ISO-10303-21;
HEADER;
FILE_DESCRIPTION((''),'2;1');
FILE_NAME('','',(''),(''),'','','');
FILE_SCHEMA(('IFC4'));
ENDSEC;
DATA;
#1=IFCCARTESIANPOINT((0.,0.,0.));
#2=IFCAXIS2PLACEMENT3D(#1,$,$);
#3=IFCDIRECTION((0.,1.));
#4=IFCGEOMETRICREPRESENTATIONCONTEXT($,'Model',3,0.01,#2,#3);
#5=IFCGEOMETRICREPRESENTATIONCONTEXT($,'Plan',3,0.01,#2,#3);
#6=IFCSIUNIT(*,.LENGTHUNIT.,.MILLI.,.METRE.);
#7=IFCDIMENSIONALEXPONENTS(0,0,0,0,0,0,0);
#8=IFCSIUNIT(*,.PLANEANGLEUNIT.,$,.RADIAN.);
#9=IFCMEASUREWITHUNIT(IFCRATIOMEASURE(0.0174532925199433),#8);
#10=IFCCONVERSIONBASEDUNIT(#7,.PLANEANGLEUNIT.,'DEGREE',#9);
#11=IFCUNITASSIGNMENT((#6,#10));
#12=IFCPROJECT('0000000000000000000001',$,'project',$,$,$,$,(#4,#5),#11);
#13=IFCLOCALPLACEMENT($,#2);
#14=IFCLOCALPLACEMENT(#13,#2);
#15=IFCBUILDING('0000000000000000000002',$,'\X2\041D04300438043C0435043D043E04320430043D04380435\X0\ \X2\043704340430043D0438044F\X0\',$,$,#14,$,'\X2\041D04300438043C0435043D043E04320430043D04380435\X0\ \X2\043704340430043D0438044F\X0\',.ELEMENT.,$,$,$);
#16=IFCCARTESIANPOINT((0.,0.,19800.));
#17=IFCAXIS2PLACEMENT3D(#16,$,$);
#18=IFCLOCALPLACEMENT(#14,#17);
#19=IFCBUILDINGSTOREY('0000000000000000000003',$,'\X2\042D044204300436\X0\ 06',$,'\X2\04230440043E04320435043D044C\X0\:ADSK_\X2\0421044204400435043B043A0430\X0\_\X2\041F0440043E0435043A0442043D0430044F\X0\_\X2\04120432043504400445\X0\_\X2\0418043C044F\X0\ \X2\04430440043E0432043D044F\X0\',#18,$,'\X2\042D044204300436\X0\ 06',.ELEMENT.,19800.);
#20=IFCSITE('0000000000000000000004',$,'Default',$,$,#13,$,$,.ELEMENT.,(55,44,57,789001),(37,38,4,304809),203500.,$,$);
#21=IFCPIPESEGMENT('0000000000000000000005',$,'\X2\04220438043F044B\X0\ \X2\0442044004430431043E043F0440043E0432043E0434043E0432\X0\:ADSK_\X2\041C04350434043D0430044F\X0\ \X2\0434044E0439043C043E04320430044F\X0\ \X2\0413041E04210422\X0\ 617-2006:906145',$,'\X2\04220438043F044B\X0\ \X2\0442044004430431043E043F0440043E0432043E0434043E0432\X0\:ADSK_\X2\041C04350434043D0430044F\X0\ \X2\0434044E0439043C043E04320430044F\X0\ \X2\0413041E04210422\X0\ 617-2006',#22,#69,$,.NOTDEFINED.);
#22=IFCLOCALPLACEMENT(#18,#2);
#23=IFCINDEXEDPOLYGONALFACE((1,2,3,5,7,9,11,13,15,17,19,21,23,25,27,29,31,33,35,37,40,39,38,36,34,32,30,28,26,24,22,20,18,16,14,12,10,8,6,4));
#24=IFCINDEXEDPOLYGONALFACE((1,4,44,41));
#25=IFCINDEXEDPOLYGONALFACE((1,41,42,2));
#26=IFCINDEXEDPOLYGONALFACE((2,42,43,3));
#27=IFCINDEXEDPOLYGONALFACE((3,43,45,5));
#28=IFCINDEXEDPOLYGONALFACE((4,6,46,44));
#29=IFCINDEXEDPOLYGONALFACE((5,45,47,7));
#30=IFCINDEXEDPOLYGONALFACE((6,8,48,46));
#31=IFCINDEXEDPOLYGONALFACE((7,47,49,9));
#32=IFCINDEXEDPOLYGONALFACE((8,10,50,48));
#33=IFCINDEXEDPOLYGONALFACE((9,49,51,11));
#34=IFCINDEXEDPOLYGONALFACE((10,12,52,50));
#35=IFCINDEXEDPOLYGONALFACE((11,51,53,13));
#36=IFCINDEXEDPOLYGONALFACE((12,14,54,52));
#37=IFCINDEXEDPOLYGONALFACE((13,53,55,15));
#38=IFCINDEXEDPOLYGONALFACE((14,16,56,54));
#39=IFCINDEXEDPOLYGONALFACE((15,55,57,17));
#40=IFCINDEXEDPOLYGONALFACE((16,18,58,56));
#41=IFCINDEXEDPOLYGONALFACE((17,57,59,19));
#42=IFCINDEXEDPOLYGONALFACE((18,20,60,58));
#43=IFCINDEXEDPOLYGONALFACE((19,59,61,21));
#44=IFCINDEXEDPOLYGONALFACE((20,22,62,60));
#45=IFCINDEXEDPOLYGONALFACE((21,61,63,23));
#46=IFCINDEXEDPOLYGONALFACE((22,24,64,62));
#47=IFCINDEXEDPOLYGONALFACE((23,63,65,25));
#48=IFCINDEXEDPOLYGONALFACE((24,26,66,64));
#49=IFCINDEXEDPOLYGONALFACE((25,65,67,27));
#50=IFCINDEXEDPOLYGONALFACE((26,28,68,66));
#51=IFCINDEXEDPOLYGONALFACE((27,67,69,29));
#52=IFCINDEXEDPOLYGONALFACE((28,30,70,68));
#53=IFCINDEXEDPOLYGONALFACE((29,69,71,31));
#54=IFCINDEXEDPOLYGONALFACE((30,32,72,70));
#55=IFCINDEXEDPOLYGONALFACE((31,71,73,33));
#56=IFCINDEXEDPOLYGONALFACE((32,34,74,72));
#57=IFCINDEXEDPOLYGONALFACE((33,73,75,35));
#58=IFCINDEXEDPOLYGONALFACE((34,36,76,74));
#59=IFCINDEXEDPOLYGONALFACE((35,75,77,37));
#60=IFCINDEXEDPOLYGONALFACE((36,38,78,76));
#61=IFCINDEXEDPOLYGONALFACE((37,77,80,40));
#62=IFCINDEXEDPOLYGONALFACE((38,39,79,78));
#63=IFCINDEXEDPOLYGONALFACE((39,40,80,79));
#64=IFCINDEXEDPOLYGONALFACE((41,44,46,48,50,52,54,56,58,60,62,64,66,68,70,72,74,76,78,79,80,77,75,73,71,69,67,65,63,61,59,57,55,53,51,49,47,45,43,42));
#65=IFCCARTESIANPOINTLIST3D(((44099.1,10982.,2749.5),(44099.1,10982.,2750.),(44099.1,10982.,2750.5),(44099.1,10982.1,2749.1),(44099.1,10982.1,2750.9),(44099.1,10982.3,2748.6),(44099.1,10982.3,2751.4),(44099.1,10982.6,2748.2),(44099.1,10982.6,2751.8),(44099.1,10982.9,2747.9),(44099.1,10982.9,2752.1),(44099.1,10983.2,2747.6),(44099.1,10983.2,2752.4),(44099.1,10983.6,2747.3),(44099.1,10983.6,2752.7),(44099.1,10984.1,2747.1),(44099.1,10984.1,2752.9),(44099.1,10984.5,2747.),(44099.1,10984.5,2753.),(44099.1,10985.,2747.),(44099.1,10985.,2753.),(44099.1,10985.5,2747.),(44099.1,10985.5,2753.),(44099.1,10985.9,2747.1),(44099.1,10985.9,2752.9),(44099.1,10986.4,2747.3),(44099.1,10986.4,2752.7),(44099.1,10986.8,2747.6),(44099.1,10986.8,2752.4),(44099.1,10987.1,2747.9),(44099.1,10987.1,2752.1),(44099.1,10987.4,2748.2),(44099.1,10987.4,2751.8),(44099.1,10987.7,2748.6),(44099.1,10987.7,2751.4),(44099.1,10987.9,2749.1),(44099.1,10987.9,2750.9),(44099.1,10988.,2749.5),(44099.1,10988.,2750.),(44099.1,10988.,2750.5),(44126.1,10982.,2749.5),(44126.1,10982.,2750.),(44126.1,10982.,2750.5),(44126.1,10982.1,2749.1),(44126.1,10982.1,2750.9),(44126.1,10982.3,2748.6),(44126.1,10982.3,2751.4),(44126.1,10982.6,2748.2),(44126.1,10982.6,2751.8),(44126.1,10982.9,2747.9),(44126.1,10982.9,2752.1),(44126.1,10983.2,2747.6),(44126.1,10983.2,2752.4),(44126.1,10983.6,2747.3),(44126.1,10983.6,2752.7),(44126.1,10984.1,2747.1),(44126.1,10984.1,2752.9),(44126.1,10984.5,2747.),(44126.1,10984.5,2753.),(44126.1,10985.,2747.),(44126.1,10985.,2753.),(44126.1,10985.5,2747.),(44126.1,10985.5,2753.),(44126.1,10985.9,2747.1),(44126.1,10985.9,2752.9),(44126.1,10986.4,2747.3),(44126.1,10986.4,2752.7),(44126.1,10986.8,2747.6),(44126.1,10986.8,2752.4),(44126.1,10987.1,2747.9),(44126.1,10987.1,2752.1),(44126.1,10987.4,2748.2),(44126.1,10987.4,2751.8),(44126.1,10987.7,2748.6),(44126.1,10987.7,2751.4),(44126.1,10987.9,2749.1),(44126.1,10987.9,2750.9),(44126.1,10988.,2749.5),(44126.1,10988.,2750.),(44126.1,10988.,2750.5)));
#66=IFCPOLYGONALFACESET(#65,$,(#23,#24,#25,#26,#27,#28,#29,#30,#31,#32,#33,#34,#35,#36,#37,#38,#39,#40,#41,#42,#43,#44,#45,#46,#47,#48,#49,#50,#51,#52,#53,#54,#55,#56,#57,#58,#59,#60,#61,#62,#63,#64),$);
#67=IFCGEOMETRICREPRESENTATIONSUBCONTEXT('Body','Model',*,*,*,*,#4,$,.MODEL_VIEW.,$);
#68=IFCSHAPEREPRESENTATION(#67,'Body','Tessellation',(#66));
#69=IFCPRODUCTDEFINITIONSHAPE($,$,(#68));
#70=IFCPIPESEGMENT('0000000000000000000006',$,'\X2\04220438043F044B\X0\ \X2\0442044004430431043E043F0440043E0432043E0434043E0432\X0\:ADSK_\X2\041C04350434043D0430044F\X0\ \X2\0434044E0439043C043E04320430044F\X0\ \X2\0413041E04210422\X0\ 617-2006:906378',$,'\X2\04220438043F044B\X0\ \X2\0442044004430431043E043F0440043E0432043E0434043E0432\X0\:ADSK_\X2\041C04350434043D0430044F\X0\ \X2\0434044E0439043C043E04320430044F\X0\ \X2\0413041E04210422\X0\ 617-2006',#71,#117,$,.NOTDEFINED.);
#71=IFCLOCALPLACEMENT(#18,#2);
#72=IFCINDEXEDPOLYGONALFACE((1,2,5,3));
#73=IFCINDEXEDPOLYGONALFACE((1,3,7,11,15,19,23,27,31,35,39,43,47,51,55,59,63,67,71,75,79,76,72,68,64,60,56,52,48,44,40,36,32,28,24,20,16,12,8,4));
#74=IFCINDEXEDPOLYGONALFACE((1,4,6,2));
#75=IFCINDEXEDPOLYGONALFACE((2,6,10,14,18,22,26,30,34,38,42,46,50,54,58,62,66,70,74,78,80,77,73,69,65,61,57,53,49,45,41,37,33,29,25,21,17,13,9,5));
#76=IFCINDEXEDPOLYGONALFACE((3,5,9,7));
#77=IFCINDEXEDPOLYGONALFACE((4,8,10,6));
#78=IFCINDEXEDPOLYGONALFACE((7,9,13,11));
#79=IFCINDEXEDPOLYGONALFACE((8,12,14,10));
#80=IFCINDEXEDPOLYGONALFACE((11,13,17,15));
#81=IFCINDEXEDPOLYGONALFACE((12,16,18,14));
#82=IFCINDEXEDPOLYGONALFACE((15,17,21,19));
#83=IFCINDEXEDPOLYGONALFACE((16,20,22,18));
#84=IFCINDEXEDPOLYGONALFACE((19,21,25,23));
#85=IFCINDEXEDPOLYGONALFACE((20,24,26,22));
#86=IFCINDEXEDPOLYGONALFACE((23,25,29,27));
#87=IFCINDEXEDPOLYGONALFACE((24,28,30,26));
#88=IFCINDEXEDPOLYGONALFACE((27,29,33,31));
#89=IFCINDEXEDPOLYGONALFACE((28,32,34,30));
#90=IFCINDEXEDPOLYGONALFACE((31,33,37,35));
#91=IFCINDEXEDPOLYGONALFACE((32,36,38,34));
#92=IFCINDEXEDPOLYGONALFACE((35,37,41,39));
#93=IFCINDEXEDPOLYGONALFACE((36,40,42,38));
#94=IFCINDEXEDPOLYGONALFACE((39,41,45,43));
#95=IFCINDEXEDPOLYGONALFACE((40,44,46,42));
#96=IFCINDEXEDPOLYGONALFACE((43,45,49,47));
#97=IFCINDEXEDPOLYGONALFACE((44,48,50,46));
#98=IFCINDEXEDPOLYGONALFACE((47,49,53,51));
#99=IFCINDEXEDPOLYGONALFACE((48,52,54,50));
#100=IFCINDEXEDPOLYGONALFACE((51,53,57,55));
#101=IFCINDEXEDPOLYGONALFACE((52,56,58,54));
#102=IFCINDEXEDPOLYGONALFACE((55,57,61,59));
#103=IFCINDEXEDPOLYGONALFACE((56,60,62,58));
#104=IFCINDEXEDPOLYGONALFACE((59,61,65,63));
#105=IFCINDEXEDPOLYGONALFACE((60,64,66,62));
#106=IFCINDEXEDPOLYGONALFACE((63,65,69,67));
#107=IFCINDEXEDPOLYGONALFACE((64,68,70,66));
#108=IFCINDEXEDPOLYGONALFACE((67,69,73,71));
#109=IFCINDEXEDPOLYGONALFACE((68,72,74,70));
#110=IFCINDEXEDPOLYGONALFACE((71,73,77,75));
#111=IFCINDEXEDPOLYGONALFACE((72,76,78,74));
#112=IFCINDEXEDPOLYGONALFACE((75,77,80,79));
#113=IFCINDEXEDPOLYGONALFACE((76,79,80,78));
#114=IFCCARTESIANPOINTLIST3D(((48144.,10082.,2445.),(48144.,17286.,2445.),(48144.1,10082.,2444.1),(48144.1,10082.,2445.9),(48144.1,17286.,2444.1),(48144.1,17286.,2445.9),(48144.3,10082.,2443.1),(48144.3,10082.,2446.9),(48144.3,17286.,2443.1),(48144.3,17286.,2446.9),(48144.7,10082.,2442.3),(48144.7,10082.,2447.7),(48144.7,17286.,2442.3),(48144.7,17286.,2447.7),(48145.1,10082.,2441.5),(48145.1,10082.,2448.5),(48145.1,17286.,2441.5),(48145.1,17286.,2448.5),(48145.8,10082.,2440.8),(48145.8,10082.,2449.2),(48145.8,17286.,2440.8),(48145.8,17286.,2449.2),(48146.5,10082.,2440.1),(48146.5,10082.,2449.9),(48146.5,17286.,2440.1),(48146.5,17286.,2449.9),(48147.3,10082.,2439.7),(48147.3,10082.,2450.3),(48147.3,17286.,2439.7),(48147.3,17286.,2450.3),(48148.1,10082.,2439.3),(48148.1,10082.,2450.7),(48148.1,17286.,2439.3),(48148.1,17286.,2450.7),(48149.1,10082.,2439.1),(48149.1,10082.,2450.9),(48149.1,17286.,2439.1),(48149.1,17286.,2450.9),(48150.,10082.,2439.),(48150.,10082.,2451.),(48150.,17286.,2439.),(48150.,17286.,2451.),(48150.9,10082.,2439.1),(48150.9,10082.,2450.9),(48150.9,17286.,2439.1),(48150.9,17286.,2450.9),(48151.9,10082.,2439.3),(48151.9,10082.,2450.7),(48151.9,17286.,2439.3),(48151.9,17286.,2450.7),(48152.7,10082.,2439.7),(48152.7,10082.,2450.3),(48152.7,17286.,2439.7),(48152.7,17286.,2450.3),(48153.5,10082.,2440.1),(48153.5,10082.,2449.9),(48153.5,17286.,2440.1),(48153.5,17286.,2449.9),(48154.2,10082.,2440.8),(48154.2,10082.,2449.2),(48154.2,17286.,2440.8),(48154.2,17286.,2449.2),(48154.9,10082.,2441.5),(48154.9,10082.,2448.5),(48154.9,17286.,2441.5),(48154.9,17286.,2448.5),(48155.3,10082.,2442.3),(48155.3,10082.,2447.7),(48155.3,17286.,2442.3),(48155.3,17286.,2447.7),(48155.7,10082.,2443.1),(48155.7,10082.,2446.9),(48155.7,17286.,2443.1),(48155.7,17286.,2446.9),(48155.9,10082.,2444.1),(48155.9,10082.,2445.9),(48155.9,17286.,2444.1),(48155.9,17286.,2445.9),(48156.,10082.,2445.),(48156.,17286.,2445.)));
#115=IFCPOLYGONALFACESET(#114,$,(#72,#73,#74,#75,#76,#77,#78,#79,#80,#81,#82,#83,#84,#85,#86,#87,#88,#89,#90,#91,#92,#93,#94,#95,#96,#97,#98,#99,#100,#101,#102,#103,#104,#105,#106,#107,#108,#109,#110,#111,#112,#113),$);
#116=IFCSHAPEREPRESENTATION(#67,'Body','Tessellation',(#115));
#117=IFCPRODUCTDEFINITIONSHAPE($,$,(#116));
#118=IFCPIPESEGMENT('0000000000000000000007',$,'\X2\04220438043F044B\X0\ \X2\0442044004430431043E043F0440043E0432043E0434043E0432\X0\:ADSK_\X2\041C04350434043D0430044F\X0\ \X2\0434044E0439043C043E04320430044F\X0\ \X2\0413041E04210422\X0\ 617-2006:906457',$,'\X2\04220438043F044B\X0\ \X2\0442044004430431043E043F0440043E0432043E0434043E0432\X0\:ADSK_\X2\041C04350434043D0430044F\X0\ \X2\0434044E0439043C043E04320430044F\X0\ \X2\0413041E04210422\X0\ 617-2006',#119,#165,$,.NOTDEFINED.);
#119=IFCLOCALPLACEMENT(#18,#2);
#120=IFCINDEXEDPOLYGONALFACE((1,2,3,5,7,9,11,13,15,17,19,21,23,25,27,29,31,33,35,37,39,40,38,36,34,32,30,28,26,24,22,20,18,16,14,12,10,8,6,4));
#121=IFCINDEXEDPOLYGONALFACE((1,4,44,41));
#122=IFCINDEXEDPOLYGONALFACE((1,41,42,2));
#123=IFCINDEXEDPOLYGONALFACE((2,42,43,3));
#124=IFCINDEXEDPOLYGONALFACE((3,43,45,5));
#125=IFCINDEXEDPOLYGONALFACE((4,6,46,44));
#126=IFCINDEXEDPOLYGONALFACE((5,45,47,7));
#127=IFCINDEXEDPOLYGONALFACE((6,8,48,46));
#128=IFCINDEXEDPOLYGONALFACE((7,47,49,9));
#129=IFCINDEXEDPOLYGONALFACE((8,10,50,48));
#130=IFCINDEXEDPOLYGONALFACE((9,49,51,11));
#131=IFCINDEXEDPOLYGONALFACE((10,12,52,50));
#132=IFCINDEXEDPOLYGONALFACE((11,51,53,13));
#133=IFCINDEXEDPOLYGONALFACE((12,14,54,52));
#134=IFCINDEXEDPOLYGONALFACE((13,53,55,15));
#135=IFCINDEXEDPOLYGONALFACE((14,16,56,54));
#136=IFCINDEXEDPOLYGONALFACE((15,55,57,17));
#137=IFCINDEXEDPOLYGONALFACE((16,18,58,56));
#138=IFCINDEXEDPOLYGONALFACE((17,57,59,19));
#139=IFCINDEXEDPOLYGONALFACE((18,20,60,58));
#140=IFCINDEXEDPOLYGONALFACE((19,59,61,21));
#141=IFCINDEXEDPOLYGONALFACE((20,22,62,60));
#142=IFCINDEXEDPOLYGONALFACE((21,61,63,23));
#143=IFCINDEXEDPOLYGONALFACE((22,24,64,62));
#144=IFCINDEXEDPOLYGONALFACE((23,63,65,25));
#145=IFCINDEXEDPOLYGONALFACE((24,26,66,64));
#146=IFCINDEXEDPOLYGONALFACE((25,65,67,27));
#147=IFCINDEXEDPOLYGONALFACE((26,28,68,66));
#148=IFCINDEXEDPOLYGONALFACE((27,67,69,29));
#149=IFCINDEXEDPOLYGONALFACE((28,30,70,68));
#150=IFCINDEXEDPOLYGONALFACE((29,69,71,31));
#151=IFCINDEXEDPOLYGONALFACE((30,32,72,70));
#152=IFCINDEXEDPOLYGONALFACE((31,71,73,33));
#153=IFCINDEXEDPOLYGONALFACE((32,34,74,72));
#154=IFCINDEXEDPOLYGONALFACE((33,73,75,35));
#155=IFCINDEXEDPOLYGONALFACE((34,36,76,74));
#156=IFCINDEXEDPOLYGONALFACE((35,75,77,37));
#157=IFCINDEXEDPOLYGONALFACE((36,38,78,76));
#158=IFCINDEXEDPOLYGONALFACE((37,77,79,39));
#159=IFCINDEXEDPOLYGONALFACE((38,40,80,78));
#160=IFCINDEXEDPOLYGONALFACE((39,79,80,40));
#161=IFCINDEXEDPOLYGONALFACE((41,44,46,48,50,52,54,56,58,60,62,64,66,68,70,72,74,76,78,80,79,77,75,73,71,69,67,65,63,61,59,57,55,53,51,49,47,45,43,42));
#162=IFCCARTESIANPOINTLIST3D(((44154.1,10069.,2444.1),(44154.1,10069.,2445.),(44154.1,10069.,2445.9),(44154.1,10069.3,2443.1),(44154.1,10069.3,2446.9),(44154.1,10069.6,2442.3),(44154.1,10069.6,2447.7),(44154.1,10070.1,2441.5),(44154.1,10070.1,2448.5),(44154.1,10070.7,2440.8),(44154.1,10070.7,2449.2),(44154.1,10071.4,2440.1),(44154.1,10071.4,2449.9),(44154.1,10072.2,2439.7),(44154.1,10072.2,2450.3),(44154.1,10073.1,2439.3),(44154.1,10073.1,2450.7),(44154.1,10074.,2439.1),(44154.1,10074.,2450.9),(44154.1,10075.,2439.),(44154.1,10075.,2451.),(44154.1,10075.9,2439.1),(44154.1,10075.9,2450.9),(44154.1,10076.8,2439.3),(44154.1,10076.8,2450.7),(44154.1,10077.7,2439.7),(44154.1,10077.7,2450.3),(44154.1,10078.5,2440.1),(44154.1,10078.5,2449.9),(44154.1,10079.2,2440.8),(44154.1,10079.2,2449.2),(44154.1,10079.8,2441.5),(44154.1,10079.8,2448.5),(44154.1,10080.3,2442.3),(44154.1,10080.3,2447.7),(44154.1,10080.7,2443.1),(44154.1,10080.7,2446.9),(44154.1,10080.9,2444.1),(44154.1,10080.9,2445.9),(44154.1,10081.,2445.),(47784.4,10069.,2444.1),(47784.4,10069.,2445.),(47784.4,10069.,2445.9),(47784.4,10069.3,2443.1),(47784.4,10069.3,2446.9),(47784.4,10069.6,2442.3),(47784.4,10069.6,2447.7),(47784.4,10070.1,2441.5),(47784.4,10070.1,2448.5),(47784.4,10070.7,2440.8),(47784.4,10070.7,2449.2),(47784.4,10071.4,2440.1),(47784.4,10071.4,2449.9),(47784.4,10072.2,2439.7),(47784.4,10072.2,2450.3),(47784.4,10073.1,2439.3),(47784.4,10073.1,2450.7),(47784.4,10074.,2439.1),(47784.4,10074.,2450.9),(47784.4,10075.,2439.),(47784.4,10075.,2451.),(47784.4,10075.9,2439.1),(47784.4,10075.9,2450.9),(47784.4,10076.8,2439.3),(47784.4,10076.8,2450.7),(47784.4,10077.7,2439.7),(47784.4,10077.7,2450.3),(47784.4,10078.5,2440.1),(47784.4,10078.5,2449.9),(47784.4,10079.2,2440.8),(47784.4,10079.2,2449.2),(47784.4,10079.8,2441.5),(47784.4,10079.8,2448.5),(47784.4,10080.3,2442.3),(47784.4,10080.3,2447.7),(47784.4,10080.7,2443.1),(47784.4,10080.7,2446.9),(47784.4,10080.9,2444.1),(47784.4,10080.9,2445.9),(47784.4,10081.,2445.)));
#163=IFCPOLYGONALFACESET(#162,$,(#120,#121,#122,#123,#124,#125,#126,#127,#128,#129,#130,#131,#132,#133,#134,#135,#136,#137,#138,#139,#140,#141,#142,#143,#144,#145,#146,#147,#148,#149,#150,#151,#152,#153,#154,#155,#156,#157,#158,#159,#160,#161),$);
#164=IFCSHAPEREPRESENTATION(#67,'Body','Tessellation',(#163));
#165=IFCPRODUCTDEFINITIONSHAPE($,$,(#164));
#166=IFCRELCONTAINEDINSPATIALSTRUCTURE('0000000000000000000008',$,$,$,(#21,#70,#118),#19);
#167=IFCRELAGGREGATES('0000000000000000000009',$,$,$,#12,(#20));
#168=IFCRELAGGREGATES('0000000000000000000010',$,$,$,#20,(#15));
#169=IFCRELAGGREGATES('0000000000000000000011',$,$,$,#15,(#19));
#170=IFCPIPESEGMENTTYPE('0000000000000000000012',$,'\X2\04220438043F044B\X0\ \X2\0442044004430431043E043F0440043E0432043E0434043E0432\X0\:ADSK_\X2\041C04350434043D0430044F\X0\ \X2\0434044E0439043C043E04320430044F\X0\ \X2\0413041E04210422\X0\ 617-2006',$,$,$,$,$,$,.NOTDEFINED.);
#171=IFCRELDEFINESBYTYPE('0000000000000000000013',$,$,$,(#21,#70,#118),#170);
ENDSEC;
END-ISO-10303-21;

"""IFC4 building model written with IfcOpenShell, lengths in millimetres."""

from ifc_helpers import new_model, entity, si_unit, converted_unit, direction, frame, origin, place, context, subcontext, project, spatial, indexed_curve, outline, extrude, type_object, element, save


model = new_model("IFC4")

# Units and contexts
model_context = context("Model", 3, precision=0.01, world=origin(), true_north=direction((0.0, 1.0)))
plan_context = context("Plan", 3, precision=0.01, world=origin(), true_north=direction((0.0, 1.0)))
body_context = subcontext(model_context, "Body", "Model", "MODEL_VIEW")
ifc_project = project(units=[si_unit("LENGTHUNIT", "METRE", prefix="MILLI"), converted_unit("PLANEANGLEUNIT", "DEGREE", entity("IfcRatioMeasure", 0.0174532925199433), si_unit("PLANEANGLEUNIT", "RADIAN"), dimensions=[0, 0, 0, 0, 0, 0, 0])], contexts=[model_context, plan_context])

# Site, building, storey
site_placement = place(None, origin())
site = spatial("IfcSite", under=ifc_project, at=site_placement, Name="Default", CompositionType="ELEMENT", RefLatitude=(55, 44, 57, 789001), RefLongitude=(37, 38, 4, 304809), RefElevation=203500.0)
building_placement = place(site_placement, origin())
building = spatial("IfcBuilding", under=site, at=building_placement, Name="Наименование здания", LongName="Наименование здания", CompositionType="ELEMENT")
storey_placement = place(building_placement, frame((0.0, 0.0, 19800.0)))
storey = spatial("IfcBuildingStorey", under=building, at=storey_placement, Name="Этаж 06", ObjectType="Уровень:ADSK_Стрелка_Проектная_Вверх_Имя уровня", LongName="Этаж 06", CompositionType="ELEMENT", Elevation=19800.0)

# Pipe segments
pipe_segment_type = type_object("IfcPipeSegmentType", Name="Типы трубопроводов:ADSK_Медная дюймовая ГОСТ 617-2006", PredefinedType="NOTDEFINED")
placement = place(storey_placement, origin())
element("IfcPipeSegment", 1, at=placement, inside=storey, type_object=pipe_segment_type, Name="Типы трубопроводов:ADSK_Медная дюймовая ГОСТ 617-2006:906145", ObjectType="Типы трубопроводов:ADSK_Медная дюймовая ГОСТ 617-2006", PredefinedType="NOTDEFINED", context=body_context, shape_type="SweptSolid", body=[
    extrude(outline(indexed_curve([(3.0, 0.0), (3.0, 0.5), (2.9, 0.9), (2.7, 1.4), (2.4, 1.8), (2.1, 2.1), (1.8, 2.4), (1.4, 2.7), (0.9, 2.9), (0.5, 3.0), (0.0, 3.0), (-0.5, 3.0), (-0.9, 2.9), (-1.4, 2.7), (-1.8, 2.4), (-2.1, 2.1), (-2.4, 1.8), (-2.7, 1.4), (-2.9, 0.9), (-3.0, 0.5), (-3.0, 0.0), (-3.0, -0.5), (-2.9, -0.9), (-2.7, -1.4), (-2.4, -1.8), (-2.1, -2.1), (-1.8, -2.4), (-1.4, -2.7), (-0.9, -2.9), (-0.5, -3.0), (0.0, -3.0), (0.5, -3.0), (0.9, -2.9), (1.4, -2.7), (1.8, -2.4), (2.1, -2.1), (2.4, -1.8), (2.7, -1.4), (2.9, -0.9), (3.0, -0.5), (3.0, 0.0)], self_intersect=False)), frame((44099.1, 10985.0, 2750.0), z_axis=(1.0, 0.0, 0.0), x_axis=(0.0, -1.0, 0.0)), (0.0, 0.0, 1.0), 27.0),
])
element("IfcPipeSegment", 2, at=placement, inside=storey, type_object=pipe_segment_type, Name="Типы трубопроводов:ADSK_Медная дюймовая ГОСТ 617-2006:906378", ObjectType="Типы трубопроводов:ADSK_Медная дюймовая ГОСТ 617-2006", PredefinedType="NOTDEFINED", context=body_context, shape_type="SweptSolid", body=[
    extrude(outline(indexed_curve([(6.0, 0.0), (5.9, 0.9), (5.7, 1.9), (5.3, 2.7), (4.9, 3.5), (4.2, 4.2), (3.5, 4.9), (2.7, 5.3), (1.9, 5.7), (0.9, 5.9), (0.0, 6.0), (-0.9, 5.9), (-1.9, 5.7), (-2.7, 5.3), (-3.5, 4.9), (-4.2, 4.2), (-4.9, 3.5), (-5.3, 2.7), (-5.7, 1.9), (-5.9, 0.9), (-6.0, 0.0), (-5.9, -0.9), (-5.7, -1.9), (-5.3, -2.7), (-4.9, -3.5), (-4.2, -4.2), (-3.5, -4.9), (-2.7, -5.3), (-1.9, -5.7), (-0.9, -5.9), (0.0, -6.0), (0.9, -5.9), (1.9, -5.7), (2.7, -5.3), (3.5, -4.9), (4.2, -4.2), (4.9, -3.5), (5.3, -2.7), (5.7, -1.9), (5.9, -0.9), (6.0, 0.0)], self_intersect=False)), frame((48150.0, 10082.0, 2445.0), z_axis=(0.0, 1.0, 0.0), x_axis=(1.0, 0.0, 0.0)), (0.0, 0.0, 1.0), 7204.0),
])
element("IfcPipeSegment", 3, at=placement, inside=storey, type_object=pipe_segment_type, Name="Типы трубопроводов:ADSK_Медная дюймовая ГОСТ 617-2006:906457", ObjectType="Типы трубопроводов:ADSK_Медная дюймовая ГОСТ 617-2006", PredefinedType="NOTDEFINED", context=body_context, shape_type="SweptSolid", body=[
    extrude(outline(indexed_curve([(6.0, 0.0), (5.9, 0.9), (5.7, 1.9), (5.3, 2.7), (4.9, 3.5), (4.2, 4.2), (3.5, 4.9), (2.7, 5.3), (1.9, 5.7), (0.9, 5.9), (0.0, 6.0), (-0.9, 5.9), (-1.9, 5.7), (-2.7, 5.3), (-3.5, 4.9), (-4.2, 4.2), (-4.9, 3.5), (-5.3, 2.7), (-5.7, 1.9), (-5.9, 0.9), (-6.0, 0.0), (-5.9, -0.9), (-5.7, -1.9), (-5.3, -2.7), (-4.9, -3.5), (-4.2, -4.2), (-3.5, -4.9), (-2.7, -5.3), (-1.9, -5.7), (-0.9, -5.9), (0.0, -6.0), (0.9, -5.9), (1.9, -5.7), (2.7, -5.3), (3.5, -4.9), (4.2, -4.2), (4.9, -3.5), (5.3, -2.7), (5.7, -1.9), (5.9, -0.9), (6.0, 0.0)], self_intersect=False)), frame((44154.1, 10075.0, 2445.0), z_axis=(1.0, 0.0, 0.0), x_axis=(0.0, -1.0, 0.0)), (0.0, 0.0, 1.0), 3630.3),
])

save(model, "model.ifc")
